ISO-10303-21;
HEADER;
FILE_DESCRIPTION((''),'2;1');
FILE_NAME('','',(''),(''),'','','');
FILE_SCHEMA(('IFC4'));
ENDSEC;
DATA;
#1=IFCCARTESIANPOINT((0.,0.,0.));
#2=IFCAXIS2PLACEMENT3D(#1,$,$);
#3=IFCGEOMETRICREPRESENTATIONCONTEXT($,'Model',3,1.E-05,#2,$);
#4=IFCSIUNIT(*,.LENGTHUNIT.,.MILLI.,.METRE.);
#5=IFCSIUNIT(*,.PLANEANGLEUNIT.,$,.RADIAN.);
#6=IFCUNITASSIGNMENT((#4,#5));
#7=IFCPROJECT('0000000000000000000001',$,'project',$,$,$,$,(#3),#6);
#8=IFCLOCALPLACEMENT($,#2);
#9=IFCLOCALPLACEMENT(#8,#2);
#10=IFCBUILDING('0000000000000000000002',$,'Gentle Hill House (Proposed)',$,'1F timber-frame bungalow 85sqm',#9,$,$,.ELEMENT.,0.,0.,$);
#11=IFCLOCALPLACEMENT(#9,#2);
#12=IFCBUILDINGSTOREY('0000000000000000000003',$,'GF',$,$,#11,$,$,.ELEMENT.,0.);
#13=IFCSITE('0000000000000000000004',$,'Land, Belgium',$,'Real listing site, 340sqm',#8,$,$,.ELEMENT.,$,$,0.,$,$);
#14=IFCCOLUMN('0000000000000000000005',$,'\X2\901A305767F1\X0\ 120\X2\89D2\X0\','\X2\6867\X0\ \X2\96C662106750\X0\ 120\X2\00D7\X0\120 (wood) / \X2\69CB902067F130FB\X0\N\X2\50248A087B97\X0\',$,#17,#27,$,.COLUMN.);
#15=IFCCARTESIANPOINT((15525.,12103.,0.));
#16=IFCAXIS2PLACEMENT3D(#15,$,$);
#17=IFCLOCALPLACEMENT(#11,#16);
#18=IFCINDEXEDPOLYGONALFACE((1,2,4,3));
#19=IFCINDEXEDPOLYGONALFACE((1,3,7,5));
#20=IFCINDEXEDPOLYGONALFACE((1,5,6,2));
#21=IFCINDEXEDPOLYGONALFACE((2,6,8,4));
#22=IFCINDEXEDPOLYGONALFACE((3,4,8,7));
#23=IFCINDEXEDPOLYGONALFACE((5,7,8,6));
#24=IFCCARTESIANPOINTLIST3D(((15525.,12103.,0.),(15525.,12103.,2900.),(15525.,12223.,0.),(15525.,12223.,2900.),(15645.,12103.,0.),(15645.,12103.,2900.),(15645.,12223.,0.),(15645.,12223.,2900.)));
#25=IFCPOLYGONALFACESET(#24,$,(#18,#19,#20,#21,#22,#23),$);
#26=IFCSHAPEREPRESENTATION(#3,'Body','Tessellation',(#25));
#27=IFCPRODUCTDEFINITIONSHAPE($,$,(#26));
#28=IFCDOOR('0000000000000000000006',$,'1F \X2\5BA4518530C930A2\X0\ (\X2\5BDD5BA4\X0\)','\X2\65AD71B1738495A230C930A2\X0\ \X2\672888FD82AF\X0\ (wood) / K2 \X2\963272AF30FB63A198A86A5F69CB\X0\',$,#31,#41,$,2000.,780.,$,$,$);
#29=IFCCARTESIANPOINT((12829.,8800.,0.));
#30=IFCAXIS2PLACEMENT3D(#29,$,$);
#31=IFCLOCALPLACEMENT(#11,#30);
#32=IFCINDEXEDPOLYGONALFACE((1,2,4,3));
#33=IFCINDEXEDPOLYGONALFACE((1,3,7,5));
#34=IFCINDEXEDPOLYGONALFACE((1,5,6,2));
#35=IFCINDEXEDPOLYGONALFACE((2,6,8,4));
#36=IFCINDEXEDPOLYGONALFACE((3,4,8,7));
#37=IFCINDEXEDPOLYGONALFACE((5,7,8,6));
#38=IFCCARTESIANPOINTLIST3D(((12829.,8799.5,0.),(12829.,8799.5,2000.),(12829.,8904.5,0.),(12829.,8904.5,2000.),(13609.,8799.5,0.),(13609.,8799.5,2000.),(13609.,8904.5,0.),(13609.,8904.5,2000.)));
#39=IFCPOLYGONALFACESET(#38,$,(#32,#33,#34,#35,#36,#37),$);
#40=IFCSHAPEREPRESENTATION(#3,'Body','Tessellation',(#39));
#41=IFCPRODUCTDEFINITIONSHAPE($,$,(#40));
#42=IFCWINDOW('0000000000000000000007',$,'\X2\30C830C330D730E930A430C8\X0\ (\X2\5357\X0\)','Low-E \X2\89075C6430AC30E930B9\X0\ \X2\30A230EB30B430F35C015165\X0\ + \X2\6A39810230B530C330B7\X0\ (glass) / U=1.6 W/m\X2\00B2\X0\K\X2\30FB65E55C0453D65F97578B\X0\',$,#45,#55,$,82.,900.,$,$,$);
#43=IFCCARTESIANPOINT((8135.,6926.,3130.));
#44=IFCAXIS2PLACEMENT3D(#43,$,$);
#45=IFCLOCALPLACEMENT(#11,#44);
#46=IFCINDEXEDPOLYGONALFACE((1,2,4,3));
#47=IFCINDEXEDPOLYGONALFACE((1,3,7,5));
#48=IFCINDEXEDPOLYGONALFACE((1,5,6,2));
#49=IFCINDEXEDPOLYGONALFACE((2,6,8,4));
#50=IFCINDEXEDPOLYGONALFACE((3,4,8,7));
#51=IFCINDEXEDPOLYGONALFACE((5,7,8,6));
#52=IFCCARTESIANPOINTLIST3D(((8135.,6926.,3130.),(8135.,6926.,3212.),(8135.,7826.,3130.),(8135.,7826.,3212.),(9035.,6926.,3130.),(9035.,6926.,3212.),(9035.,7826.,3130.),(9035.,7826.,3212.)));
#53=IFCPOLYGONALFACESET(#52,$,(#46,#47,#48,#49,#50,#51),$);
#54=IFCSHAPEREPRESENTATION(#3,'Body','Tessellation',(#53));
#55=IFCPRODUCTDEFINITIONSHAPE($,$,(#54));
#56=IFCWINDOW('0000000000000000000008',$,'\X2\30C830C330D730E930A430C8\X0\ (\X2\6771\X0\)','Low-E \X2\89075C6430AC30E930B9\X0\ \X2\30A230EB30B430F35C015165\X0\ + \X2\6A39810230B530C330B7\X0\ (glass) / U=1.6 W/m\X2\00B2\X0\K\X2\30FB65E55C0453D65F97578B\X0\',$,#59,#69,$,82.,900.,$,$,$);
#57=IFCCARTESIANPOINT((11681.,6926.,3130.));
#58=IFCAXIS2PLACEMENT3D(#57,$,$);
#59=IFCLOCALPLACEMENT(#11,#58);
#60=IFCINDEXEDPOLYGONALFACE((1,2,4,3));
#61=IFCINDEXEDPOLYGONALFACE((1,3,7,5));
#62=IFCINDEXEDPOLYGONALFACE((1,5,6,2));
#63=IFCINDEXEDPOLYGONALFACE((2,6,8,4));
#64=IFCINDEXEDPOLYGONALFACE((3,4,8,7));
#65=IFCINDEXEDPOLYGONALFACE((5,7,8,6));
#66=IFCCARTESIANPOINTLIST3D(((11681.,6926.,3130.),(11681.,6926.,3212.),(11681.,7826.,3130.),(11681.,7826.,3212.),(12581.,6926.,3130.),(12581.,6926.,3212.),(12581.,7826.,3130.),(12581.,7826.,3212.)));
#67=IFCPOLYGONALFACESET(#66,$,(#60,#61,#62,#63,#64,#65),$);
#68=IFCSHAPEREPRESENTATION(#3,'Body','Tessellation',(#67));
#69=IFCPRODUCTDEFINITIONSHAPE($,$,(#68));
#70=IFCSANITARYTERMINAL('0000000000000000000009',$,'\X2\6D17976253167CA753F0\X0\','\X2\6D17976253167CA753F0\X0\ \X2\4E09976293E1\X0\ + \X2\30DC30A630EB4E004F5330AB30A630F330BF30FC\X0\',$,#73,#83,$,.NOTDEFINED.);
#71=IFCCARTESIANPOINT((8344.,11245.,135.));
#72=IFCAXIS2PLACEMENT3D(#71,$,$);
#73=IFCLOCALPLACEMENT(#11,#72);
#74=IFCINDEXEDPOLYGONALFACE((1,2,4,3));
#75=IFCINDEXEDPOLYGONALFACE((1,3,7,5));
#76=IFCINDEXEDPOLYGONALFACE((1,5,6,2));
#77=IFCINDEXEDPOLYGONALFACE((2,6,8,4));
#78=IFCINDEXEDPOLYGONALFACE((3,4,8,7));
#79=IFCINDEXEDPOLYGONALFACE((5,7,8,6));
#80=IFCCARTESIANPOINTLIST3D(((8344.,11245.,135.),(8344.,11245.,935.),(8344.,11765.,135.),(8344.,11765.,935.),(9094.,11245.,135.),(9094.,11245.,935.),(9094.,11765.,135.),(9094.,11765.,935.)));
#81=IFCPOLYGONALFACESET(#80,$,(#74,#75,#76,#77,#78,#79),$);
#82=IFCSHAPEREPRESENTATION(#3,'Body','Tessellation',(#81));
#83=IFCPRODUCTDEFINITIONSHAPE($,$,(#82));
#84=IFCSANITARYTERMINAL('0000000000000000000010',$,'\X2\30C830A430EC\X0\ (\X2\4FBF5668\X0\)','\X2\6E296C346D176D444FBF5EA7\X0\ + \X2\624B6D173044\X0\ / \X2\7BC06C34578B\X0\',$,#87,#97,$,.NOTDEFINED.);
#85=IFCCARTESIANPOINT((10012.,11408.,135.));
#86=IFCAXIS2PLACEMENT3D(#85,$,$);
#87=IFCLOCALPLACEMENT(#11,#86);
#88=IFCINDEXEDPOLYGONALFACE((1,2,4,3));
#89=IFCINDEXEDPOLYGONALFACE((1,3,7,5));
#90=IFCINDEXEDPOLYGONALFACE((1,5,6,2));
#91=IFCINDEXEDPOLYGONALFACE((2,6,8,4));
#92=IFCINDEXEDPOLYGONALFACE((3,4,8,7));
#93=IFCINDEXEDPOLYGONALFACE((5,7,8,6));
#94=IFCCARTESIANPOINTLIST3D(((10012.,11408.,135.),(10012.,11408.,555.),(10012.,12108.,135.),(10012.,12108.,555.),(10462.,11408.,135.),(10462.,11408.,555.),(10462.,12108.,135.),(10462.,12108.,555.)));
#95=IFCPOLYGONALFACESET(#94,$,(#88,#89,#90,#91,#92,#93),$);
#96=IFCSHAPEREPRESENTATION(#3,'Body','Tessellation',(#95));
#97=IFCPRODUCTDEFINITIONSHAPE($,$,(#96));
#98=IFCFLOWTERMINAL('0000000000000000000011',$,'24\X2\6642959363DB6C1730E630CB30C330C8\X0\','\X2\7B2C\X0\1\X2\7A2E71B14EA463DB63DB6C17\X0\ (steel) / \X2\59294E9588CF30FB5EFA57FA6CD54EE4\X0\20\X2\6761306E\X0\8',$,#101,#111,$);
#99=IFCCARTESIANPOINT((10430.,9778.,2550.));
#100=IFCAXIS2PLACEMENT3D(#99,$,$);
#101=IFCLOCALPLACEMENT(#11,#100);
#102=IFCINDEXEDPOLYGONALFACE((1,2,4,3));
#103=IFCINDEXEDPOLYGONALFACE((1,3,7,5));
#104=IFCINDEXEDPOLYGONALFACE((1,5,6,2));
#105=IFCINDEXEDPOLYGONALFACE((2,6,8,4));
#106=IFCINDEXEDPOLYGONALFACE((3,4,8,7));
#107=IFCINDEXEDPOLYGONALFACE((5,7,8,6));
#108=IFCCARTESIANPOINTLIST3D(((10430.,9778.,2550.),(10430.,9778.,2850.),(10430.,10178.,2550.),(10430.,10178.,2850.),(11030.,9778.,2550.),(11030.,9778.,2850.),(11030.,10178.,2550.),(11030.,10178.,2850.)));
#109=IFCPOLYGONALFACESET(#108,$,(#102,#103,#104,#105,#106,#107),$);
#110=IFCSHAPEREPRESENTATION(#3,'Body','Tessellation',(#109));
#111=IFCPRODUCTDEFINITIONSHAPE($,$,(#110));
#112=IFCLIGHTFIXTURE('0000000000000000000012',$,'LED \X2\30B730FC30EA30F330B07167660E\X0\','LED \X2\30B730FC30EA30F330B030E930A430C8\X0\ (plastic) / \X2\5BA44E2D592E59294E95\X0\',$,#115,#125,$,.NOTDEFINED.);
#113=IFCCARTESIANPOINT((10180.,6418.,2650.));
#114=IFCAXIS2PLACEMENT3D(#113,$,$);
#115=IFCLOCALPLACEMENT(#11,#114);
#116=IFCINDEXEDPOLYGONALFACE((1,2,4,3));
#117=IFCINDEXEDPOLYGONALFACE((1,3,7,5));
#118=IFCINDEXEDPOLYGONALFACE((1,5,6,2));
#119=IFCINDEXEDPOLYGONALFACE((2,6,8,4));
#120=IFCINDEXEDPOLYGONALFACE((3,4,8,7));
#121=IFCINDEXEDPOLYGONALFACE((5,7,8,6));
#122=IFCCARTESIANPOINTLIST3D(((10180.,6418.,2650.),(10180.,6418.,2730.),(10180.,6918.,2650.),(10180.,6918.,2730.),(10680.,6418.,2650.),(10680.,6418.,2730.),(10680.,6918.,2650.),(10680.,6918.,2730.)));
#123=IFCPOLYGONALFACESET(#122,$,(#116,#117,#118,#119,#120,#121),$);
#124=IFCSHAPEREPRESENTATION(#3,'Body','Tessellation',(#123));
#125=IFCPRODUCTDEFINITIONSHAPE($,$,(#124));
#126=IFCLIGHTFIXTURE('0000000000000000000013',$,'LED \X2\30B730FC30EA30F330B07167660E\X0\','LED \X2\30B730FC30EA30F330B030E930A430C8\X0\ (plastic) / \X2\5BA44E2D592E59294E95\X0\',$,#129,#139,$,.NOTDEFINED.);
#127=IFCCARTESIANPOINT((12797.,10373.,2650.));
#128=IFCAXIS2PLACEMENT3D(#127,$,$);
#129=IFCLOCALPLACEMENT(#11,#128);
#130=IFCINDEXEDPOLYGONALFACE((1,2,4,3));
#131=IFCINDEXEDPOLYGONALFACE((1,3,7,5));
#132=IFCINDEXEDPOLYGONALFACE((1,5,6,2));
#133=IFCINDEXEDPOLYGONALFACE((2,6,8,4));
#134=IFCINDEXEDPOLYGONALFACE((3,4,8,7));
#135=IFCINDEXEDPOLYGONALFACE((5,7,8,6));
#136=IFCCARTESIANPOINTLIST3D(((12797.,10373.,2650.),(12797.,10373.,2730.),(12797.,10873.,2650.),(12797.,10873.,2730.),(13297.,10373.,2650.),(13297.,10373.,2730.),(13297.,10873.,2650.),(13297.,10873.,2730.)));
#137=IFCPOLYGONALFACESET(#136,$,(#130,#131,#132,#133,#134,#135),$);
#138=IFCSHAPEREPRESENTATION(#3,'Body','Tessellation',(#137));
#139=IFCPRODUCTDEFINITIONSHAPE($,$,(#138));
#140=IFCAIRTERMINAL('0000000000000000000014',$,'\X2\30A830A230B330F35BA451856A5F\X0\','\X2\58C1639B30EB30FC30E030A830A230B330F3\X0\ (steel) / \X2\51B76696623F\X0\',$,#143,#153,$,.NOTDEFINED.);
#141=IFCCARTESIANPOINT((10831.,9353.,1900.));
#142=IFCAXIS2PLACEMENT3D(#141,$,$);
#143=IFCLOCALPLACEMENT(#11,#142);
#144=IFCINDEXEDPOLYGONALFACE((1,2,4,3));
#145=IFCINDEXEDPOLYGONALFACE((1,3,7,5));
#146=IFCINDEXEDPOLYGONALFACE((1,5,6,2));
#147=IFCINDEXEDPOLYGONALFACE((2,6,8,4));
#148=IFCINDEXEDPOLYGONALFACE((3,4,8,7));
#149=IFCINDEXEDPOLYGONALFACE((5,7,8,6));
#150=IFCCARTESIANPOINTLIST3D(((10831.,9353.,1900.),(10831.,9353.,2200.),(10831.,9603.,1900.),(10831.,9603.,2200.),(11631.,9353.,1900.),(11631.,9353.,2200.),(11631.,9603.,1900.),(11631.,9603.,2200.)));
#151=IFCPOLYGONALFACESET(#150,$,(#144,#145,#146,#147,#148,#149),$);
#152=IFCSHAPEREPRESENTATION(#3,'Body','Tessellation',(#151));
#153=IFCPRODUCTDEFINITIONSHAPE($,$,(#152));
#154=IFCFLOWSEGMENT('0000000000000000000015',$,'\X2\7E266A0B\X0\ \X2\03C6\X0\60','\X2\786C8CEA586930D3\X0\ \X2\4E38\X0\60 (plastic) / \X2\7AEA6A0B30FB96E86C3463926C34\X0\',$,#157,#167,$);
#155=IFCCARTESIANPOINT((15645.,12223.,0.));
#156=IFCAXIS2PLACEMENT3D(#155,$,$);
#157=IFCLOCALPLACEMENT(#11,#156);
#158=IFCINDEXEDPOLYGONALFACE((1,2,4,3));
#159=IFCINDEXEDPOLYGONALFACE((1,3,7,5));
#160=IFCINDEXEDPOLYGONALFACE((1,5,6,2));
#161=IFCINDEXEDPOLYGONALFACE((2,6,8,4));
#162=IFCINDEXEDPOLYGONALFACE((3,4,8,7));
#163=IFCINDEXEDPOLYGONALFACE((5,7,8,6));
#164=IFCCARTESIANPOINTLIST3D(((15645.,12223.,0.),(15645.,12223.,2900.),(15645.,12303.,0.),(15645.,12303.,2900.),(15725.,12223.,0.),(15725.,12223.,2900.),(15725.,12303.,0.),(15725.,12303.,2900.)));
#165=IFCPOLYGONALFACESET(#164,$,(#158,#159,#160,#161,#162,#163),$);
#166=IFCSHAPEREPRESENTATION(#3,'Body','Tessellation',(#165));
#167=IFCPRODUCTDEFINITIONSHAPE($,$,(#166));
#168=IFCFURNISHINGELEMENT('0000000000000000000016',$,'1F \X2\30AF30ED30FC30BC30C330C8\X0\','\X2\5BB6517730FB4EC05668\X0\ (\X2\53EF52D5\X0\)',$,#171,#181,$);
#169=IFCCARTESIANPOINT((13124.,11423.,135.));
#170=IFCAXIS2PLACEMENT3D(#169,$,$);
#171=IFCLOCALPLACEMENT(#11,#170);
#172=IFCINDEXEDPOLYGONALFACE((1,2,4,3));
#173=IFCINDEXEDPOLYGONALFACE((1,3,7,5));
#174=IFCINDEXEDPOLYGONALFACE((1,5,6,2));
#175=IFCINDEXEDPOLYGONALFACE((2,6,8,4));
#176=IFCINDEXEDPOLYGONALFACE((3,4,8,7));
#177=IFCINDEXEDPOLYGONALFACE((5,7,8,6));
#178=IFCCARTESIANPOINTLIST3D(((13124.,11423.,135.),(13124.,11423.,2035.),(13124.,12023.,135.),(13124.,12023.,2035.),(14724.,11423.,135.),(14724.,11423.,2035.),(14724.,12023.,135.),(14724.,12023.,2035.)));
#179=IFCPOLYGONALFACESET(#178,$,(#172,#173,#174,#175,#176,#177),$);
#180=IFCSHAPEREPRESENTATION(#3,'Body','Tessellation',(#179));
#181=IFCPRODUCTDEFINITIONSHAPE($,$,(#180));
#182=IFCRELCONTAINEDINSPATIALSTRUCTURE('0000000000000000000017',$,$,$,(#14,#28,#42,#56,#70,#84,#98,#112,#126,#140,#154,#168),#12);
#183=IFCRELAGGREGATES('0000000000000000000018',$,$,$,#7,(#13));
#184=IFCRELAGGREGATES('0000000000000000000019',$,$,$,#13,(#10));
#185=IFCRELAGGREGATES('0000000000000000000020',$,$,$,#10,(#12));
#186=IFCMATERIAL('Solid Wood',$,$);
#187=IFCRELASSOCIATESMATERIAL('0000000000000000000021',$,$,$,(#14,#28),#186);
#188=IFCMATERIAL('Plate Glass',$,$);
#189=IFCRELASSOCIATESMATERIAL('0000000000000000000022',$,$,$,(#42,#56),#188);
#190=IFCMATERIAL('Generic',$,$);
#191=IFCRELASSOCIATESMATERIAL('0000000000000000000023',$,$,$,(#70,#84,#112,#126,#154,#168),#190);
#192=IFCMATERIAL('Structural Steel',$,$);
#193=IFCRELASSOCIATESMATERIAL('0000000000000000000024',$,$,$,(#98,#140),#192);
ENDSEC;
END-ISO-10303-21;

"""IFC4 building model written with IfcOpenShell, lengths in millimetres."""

from ifc_helpers import new_model, si_unit, frame, frame_2d, origin, place, context, project, spatial, rectangle, extrude, material, element, save


model = new_model("IFC4")

# Units and contexts
model_context = context("Model", 3, precision=1e-05, world=origin())
ifc_project = project(units=[si_unit("LENGTHUNIT", "METRE", prefix="MILLI"), si_unit("PLANEANGLEUNIT", "RADIAN")], contexts=[model_context])

# Site, building, storey
site_placement = place(None, origin())
site = spatial("IfcSite", under=ifc_project, at=site_placement, Name="Land, Belgium", ObjectType="Real listing site, 340sqm", CompositionType="ELEMENT", RefElevation=0.0)
building_placement = place(site_placement, origin())
building = spatial("IfcBuilding", under=site, at=building_placement, Name="Gentle Hill House (Proposed)", ObjectType="1F timber-frame bungalow 85sqm", CompositionType="ELEMENT", ElevationOfRefHeight=0.0, ElevationOfTerrain=0.0)
storey_placement = place(building_placement, origin())
storey = spatial("IfcBuildingStorey", under=building, at=storey_placement, Name="GF", CompositionType="ELEMENT", Elevation=0.0)

# Column
ifc_material_1 = material(Name="Solid Wood")
column_1_placement = place(storey_placement, frame((15525.0, 12103.0, 0.0)))
element("IfcColumn", 1, at=column_1_placement, inside=storey, material=ifc_material_1, Name="通し柱 120角", Description="桧 集成材 120×120 (wood) / 構造柱・N値計算", PredefinedType="COLUMN", context=model_context, shape_type="SweptSolid", body=[
    extrude(rectangle(XDim=120.0, YDim=120.0, at=frame_2d((60.0, 60.0))), frame((15525.0, 12103.0, 0.0)), (0.0, 0.0, 1.0), 2900.0),
])

# Door
door_placement = place(storey_placement, frame((12829.0, 8800.0, 0.0)))
element("IfcDoor", 2, at=door_placement, inside=storey, material=ifc_material_1, Name="1F 室内ドア (寝室)", Description="断熱玄関ドア 木製芯 (wood) / K2 防犯・採風機構", OverallHeight=2000.0, OverallWidth=780.0, context=model_context, shape_type="SweptSolid", body=[
    extrude(rectangle(XDim=780.0, YDim=105.0, at=frame_2d((390.0, 52.0))), frame((12829.0, 8800.0, 0.0)), (0.0, 0.0, 1.0), 2000.0),
])

# Windows
ifc_material_2 = material(Name="Plate Glass")
window_1_placement = place(storey_placement, frame((8135.0, 6926.0, 3130.0)))
element("IfcWindow", 3, at=window_1_placement, inside=storey, material=ifc_material_2, Name="トップライト (南)", Description="Low-E 複層ガラス アルゴン封入 + 樹脂サッシ (glass) / U=1.6 W/m²K・日射取得型", OverallHeight=82.0, OverallWidth=900.0, context=model_context, shape_type="SweptSolid", body=[
    extrude(rectangle(XDim=900.0, YDim=900.0, at=frame_2d((450.0, 450.0))), frame((8135.0, 6926.0, 3130.0)), (0.0, 0.0, 1.0), 82.0),
])
window_2_placement = place(storey_placement, frame((11681.0, 6926.0, 3130.0)))
element("IfcWindow", 4, at=window_2_placement, inside=storey, material=ifc_material_2, Name="トップライト (東)", Description="Low-E 複層ガラス アルゴン封入 + 樹脂サッシ (glass) / U=1.6 W/m²K・日射取得型", OverallHeight=82.0, OverallWidth=900.0, context=model_context, shape_type="SweptSolid", body=[
    extrude(rectangle(XDim=900.0, YDim=900.0, at=frame_2d((450.0, 450.0))), frame((11681.0, 6926.0, 3130.0)), (0.0, 0.0, 1.0), 82.0),
])

# Sanitary terminals
ifc_material_3 = material(Name="Generic")
sanitary_terminal_1_placement = place(storey_placement, frame((8344.0, 11245.0, 135.0)))
element("IfcSanitaryTerminal", 5, at=sanitary_terminal_1_placement, inside=storey, material=ifc_material_3, Name="洗面化粧台", Description="洗面化粧台 三面鏡 + ボウル一体カウンター", PredefinedType="NOTDEFINED", context=model_context, shape_type="SweptSolid", body=[
    extrude(rectangle(XDim=750.0, YDim=520.0, at=frame_2d((375.0, 260.0))), frame((8344.0, 11245.0, 135.0)), (0.0, 0.0, 1.0), 800.0),
])
sanitary_terminal_2_placement = place(storey_placement, frame((10012.0, 11408.0, 135.0)))
element("IfcSanitaryTerminal", 6, at=sanitary_terminal_2_placement, inside=storey, material=ifc_material_3, Name="トイレ (便器)", Description="温水洗浄便座 + 手洗い / 節水型", PredefinedType="NOTDEFINED", context=model_context, shape_type="SweptSolid", body=[
    extrude(rectangle(XDim=450.0, YDim=700.0, at=frame_2d((225.0, 350.0))), frame((10012.0, 11408.0, 135.0)), (0.0, 0.0, 1.0), 420.0),
])

# Flow terminal
ifc_material_4 = material(Name="Structural Steel")
flow_terminal_placement = place(storey_placement, frame((10430.0, 9778.0, 2550.0)))
element("IfcFlowTerminal", 7, at=flow_terminal_placement, inside=storey, material=ifc_material_4, Name="24時間換気ユニット", Description="第1種熱交換換気 (steel) / 天井裏・建基法令20条の8", context=model_context, shape_type="SweptSolid", body=[
    extrude(rectangle(XDim=600.0, YDim=400.0, at=frame_2d((300.0, 200.0))), frame((10430.0, 9778.0, 2550.0)), (0.0, 0.0, 1.0), 300.0),
])

# Light fixtures
light_fixture_1_placement = place(storey_placement, frame((10180.0, 6418.0, 2650.0)))
element("IfcLightFixture", 8, at=light_fixture_1_placement, inside=storey, material=ifc_material_3, Name="LED シーリング照明", Description="LED シーリングライト (plastic) / 室中央天井", PredefinedType="NOTDEFINED", context=model_context, shape_type="SweptSolid", body=[
    extrude(rectangle(XDim=500.0, YDim=500.0, at=frame_2d((250.0, 250.0))), frame((10180.0, 6418.0, 2650.0)), (0.0, 0.0, 1.0), 80.0),
])
light_fixture_2_placement = place(storey_placement, frame((12797.0, 10373.0, 2650.0)))
element("IfcLightFixture", 9, at=light_fixture_2_placement, inside=storey, material=ifc_material_3, Name="LED シーリング照明", Description="LED シーリングライト (plastic) / 室中央天井", PredefinedType="NOTDEFINED", context=model_context, shape_type="SweptSolid", body=[
    extrude(rectangle(XDim=500.0, YDim=500.0, at=frame_2d((250.0, 250.0))), frame((12797.0, 10373.0, 2650.0)), (0.0, 0.0, 1.0), 80.0),
])

# Air terminal
air_terminal_placement = place(storey_placement, frame((10831.0, 9353.0, 1900.0)))
element("IfcAirTerminal", 10, at=air_terminal_placement, inside=storey, material=ifc_material_4, Name="エアコン室内機", Description="壁掛ルームエアコン (steel) / 冷暖房", PredefinedType="NOTDEFINED", context=model_context, shape_type="SweptSolid", body=[
    extrude(rectangle(XDim=800.0, YDim=250.0, at=frame_2d((400.0, 125.0))), frame((10831.0, 9353.0, 1900.0)), (0.0, 0.0, 1.0), 300.0),
])

# Flow segment
flow_segment_placement = place(storey_placement, frame((15645.0, 12223.0, 0.0)))
element("IfcFlowSegment", 11, at=flow_segment_placement, inside=storey, material=ifc_material_3, Name="縦樋 φ60", Description="硬質塩ビ 丸60 (plastic) / 竪樋・雨水排水", context=model_context, shape_type="SweptSolid", body=[
    extrude(rectangle(XDim=80.0, YDim=80.0, at=frame_2d((40.0, 40.0))), frame((15645.0, 12223.0, 0.0)), (0.0, 0.0, 1.0), 2900.0),
])

# Furnishing element
furnishing_placement = place(storey_placement, frame((13124.0, 11423.0, 135.0)))
element("IfcFurnishingElement", 12, at=furnishing_placement, inside=storey, material=ifc_material_3, Name="1F クローゼット", Description="家具・什器 (可動)", context=model_context, shape_type="SweptSolid", body=[
    extrude(rectangle(XDim=1600.0, YDim=600.0, at=frame_2d((800.0, 300.0))), frame((13124.0, 11423.0, 135.0)), (0.0, 0.0, 1.0), 1900.0),
])

save(model, "model.ifc")
